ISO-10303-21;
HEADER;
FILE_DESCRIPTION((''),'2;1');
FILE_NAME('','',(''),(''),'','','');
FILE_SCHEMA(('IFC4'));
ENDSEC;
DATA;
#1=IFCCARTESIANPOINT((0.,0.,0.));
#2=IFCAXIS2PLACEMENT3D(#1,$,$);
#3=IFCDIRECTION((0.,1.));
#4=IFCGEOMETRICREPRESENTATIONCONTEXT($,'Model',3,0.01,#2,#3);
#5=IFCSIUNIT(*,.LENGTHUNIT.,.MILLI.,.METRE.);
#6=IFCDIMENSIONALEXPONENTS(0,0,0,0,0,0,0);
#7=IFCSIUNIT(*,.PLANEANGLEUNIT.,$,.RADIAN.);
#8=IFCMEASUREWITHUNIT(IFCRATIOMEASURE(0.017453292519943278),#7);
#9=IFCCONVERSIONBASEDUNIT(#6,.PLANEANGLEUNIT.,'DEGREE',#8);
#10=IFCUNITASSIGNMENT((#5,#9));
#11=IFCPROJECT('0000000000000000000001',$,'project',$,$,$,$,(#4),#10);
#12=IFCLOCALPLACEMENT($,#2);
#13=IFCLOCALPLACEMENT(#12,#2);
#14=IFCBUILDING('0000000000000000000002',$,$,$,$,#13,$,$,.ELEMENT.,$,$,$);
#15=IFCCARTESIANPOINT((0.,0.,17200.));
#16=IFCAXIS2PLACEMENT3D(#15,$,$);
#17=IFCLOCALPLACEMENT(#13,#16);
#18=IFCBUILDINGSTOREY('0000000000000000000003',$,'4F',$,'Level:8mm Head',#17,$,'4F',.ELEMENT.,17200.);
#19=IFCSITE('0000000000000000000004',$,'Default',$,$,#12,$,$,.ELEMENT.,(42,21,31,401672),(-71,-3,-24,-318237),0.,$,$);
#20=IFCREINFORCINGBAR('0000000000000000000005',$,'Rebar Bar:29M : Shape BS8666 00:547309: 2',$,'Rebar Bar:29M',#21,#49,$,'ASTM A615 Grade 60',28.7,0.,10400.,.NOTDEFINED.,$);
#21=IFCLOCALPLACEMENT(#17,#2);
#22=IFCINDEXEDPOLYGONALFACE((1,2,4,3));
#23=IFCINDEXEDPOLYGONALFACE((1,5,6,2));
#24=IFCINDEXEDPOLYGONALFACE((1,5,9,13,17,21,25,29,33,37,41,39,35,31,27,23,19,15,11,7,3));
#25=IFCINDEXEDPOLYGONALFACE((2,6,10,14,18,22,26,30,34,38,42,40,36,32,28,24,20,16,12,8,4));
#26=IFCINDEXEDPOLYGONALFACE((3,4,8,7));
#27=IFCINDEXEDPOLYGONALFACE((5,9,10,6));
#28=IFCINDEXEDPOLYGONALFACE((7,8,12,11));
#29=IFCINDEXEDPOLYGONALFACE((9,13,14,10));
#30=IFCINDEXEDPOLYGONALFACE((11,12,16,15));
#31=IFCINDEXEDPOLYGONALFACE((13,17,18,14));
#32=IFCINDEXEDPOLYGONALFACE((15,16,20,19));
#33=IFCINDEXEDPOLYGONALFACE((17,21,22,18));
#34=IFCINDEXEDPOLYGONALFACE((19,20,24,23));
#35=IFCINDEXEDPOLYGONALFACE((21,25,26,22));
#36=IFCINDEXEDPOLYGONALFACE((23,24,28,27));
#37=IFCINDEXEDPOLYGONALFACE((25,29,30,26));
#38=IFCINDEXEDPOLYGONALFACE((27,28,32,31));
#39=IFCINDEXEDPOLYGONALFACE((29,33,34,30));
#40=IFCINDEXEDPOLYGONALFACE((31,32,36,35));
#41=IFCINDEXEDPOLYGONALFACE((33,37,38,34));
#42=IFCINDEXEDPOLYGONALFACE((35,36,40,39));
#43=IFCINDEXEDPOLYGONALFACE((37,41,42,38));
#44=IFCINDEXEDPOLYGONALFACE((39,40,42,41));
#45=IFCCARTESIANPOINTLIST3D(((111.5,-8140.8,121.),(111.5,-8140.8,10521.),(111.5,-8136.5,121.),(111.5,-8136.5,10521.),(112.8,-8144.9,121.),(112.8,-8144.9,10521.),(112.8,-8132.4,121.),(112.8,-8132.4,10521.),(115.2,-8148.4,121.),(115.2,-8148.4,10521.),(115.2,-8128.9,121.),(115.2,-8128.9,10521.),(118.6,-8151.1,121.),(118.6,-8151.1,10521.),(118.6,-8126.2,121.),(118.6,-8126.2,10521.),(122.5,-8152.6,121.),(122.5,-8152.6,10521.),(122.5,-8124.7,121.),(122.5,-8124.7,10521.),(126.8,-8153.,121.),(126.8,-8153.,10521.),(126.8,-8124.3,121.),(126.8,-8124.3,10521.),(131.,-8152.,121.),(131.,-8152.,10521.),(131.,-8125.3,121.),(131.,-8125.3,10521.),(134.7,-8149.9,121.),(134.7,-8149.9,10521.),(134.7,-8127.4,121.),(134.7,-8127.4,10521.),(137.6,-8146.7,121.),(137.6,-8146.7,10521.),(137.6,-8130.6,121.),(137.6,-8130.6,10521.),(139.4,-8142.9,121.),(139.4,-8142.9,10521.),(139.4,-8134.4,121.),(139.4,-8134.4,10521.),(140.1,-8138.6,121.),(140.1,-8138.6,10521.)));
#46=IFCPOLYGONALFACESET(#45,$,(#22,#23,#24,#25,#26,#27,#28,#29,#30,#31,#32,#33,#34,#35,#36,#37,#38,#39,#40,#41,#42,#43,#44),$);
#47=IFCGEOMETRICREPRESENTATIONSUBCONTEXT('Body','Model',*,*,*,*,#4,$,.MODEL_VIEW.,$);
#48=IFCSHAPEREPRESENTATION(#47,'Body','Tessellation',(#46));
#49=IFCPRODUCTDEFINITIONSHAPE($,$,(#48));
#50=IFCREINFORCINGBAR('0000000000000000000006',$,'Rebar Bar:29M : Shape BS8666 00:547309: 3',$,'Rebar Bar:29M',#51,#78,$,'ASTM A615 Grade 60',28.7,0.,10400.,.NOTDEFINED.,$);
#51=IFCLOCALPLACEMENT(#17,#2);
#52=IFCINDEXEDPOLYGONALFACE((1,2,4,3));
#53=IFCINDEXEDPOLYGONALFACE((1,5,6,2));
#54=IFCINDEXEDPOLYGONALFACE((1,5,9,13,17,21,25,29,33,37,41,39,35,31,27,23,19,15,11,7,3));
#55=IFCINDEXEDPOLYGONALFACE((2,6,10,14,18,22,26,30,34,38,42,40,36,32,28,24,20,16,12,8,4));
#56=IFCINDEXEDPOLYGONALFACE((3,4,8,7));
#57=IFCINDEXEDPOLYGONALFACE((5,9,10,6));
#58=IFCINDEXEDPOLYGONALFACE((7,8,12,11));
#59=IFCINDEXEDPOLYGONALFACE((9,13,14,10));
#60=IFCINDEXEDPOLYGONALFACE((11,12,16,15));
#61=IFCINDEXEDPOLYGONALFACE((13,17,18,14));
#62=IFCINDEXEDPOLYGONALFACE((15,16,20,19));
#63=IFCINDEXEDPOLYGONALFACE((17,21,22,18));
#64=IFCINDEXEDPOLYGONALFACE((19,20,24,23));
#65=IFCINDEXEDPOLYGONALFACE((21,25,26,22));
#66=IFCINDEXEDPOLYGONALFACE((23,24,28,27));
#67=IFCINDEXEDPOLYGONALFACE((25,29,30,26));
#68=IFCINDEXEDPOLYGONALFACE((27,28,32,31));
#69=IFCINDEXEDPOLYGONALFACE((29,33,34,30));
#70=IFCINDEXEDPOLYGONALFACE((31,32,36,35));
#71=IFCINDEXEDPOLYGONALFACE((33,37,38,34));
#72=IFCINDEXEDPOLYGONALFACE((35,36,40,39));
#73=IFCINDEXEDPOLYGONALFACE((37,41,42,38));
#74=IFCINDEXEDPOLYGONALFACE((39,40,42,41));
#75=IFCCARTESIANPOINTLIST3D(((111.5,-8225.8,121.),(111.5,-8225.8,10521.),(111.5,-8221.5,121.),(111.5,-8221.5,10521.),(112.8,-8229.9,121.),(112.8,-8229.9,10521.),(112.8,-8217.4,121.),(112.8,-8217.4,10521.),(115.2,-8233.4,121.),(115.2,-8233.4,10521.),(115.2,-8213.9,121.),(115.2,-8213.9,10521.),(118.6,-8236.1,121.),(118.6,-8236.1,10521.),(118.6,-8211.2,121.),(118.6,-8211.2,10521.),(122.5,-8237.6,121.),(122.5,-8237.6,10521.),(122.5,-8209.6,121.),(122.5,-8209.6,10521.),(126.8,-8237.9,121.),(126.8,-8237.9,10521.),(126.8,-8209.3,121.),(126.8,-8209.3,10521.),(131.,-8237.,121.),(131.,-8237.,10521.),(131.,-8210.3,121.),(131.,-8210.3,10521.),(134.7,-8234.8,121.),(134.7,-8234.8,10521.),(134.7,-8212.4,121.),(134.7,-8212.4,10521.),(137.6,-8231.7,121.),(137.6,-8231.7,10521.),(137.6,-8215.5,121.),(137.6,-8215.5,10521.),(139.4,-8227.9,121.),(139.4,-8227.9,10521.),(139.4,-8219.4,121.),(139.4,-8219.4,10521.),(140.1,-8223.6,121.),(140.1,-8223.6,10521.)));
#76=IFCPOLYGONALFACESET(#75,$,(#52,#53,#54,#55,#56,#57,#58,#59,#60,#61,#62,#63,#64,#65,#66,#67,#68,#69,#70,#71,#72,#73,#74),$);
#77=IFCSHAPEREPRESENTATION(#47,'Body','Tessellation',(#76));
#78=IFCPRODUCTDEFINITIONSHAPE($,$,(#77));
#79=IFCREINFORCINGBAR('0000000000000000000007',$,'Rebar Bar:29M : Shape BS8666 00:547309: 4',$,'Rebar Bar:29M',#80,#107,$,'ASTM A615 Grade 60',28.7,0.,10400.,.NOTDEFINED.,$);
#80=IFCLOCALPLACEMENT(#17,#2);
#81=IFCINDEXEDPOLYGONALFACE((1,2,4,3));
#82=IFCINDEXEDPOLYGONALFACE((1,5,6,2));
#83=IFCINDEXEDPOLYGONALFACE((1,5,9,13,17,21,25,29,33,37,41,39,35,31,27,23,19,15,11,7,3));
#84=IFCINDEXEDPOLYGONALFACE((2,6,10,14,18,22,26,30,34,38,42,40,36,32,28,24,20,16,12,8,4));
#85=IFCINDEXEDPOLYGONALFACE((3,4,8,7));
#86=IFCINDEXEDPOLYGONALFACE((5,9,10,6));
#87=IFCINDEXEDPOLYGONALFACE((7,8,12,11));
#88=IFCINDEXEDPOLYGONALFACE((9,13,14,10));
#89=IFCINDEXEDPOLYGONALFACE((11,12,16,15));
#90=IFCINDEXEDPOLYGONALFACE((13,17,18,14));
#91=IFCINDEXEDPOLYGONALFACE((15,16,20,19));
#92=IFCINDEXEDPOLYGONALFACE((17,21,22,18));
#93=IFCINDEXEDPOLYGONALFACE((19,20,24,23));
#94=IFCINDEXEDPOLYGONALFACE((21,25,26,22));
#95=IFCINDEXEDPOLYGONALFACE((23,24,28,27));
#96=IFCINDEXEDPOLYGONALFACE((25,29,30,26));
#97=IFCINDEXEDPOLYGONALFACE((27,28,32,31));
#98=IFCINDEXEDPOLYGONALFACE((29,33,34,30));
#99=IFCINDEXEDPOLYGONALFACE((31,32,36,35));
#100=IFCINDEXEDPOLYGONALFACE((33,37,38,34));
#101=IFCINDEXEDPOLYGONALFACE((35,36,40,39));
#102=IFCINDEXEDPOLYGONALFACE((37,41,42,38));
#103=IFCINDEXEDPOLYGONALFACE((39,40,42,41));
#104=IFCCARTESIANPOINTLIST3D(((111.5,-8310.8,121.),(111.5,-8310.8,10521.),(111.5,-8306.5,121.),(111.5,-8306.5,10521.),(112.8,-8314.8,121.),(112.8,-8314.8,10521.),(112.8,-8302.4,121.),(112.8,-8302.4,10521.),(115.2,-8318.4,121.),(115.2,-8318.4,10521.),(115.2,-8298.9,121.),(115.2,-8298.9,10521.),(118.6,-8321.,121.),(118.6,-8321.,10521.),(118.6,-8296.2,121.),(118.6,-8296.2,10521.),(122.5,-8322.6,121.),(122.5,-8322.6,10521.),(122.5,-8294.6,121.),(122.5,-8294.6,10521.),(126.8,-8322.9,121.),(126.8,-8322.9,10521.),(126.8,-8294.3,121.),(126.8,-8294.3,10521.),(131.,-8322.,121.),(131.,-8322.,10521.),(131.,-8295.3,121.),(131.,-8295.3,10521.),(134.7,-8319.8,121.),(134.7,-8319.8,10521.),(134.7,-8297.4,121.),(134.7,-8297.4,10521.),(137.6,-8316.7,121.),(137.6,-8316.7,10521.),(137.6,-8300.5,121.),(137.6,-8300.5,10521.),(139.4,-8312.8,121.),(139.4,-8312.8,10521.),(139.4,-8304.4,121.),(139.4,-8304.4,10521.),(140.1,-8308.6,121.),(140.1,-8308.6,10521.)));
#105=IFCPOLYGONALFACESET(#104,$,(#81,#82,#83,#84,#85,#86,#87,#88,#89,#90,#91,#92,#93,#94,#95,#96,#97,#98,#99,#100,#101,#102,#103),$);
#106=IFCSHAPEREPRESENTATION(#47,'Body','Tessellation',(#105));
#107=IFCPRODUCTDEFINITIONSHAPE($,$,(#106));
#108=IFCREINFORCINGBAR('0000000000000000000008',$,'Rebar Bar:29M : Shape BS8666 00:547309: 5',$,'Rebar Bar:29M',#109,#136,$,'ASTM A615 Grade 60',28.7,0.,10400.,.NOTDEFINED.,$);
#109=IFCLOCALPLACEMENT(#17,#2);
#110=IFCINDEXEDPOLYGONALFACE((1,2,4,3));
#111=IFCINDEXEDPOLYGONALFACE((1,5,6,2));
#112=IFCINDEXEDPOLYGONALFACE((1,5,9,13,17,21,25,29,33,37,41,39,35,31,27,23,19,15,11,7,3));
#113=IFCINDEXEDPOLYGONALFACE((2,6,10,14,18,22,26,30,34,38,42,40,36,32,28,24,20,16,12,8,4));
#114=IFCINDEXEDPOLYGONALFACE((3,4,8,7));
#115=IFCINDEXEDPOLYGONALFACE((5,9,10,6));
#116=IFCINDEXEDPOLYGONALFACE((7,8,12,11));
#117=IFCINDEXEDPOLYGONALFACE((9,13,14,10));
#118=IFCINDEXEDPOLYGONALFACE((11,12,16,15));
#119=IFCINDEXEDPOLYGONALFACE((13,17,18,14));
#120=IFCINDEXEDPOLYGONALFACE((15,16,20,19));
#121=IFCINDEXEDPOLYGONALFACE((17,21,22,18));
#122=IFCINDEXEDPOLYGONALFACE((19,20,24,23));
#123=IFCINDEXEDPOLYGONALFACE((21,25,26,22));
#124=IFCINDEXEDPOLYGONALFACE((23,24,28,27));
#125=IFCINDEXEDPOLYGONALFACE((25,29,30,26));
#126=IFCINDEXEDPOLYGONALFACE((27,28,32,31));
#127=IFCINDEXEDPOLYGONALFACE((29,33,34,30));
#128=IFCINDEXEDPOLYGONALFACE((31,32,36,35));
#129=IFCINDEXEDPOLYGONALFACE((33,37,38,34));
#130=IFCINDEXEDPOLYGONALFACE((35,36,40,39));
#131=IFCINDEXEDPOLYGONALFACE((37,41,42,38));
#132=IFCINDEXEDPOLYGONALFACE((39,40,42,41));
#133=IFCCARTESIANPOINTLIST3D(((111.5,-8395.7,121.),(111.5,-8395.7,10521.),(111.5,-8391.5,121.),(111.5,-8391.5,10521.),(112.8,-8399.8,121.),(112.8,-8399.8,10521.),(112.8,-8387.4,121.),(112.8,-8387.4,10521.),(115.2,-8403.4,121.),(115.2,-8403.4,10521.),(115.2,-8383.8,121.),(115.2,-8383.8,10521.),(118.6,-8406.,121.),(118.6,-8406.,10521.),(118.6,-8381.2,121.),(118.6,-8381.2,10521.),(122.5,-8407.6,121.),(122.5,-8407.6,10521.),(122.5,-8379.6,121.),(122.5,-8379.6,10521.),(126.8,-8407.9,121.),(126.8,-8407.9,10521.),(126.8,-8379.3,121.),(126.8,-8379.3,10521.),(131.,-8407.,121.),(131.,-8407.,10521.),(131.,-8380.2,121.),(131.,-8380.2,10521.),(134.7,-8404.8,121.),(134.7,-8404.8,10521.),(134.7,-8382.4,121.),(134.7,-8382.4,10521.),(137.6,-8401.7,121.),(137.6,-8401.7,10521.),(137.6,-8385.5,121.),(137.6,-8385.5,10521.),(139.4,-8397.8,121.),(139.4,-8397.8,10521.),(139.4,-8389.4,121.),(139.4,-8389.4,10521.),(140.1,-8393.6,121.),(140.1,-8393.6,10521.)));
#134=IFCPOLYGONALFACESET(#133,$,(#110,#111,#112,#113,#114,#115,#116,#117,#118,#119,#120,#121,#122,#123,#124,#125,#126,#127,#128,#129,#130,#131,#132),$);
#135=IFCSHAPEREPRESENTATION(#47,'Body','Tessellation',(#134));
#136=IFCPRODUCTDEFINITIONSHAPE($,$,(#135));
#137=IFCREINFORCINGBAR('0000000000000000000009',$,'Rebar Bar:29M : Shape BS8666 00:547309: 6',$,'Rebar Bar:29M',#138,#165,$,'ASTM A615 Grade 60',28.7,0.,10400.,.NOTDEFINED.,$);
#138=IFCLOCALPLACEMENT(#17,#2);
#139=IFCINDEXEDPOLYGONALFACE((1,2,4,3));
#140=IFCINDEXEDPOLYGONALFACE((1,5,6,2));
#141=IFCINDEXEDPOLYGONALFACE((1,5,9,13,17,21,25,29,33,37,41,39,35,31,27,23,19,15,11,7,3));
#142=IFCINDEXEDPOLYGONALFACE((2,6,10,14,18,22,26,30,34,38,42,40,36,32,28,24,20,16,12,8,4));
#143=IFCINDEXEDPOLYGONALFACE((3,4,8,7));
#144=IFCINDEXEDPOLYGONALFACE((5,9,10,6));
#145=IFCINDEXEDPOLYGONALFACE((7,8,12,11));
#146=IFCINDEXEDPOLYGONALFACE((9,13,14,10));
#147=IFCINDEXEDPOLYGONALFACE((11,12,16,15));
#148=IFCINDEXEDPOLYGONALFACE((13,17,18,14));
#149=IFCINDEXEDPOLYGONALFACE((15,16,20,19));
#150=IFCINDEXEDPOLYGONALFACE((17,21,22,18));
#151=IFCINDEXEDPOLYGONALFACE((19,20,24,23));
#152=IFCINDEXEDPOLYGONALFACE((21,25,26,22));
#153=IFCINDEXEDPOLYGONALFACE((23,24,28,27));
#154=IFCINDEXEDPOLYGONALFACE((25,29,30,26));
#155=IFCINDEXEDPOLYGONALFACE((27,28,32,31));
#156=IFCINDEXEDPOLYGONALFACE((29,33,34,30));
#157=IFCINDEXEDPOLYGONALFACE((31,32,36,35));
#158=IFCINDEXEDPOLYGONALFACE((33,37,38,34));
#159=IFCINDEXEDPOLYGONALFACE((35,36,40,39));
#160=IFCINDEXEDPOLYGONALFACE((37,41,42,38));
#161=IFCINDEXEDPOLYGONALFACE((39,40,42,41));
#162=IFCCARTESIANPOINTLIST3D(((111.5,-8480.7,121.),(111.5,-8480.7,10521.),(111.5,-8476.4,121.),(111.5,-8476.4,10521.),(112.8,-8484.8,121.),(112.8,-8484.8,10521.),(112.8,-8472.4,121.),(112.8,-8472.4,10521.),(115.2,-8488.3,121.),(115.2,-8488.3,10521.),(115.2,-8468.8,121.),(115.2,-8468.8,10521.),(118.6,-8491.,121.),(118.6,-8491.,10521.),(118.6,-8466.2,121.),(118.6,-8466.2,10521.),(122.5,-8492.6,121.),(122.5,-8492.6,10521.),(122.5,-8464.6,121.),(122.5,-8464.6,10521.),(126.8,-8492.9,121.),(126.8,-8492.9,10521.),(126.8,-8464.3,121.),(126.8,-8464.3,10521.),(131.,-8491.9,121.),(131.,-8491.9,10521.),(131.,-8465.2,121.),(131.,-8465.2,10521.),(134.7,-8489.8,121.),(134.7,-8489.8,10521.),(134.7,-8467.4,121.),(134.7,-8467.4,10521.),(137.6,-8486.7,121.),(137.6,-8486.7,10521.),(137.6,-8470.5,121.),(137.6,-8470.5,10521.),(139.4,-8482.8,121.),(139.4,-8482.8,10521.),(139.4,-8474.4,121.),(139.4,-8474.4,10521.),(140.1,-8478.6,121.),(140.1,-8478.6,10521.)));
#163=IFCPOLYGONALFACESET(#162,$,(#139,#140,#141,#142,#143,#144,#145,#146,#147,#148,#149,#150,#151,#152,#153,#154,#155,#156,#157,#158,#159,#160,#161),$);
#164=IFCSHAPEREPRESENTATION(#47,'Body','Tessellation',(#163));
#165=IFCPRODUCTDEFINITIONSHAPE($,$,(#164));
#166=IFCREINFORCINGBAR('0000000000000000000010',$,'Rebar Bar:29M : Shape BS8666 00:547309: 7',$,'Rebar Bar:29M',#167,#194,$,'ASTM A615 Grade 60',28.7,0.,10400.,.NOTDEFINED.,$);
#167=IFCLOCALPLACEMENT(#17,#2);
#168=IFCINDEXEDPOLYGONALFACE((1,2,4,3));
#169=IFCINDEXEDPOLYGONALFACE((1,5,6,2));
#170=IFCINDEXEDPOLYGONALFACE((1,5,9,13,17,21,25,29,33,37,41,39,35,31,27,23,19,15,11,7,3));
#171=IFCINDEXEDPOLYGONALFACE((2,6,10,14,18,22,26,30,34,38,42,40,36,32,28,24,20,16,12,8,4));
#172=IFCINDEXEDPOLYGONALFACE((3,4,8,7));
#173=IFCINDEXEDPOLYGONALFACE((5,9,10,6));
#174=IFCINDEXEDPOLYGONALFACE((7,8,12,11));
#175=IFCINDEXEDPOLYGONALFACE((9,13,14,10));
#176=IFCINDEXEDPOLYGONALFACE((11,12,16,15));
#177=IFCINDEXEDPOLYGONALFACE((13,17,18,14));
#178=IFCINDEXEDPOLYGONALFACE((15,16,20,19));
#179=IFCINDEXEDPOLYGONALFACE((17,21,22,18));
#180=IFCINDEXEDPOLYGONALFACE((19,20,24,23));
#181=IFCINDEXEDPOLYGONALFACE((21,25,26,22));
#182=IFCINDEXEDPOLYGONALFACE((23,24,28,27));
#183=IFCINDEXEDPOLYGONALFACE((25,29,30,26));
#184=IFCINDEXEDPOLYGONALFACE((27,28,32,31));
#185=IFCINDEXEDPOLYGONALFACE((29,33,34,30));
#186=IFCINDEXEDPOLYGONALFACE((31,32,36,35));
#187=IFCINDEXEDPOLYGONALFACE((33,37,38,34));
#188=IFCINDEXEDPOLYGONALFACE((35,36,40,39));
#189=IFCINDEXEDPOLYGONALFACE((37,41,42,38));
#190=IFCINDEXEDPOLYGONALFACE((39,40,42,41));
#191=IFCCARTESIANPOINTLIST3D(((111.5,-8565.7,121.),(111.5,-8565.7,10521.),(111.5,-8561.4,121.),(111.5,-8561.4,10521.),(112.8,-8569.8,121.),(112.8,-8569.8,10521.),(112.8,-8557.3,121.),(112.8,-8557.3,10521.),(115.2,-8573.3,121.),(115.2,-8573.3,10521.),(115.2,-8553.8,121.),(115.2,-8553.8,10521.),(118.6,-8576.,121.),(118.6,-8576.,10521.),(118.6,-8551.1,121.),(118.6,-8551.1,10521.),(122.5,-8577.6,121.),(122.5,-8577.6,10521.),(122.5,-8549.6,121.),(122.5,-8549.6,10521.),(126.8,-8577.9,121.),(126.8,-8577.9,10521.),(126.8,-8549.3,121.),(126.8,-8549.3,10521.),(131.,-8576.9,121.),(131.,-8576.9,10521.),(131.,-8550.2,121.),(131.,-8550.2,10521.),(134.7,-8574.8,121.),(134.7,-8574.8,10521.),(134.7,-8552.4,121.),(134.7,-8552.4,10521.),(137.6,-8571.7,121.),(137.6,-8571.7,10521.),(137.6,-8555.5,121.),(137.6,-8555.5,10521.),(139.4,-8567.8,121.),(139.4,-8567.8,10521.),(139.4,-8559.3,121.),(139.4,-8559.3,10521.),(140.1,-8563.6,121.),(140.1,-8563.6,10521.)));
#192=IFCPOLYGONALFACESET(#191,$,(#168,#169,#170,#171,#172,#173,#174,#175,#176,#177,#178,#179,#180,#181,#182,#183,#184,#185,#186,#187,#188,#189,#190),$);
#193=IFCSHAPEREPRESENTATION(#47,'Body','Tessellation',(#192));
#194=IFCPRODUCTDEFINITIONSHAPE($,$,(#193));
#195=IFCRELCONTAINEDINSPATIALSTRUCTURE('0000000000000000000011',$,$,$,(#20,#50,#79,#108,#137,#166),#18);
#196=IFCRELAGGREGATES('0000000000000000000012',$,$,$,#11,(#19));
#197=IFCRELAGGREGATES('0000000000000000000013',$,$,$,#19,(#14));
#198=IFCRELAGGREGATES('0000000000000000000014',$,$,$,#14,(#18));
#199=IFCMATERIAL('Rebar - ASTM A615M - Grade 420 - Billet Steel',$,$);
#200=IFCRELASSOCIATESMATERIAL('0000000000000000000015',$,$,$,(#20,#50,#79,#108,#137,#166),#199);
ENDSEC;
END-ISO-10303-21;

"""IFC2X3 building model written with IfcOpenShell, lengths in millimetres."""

from ifc_helpers import new_model, entity, si_unit, converted_unit, direction, frame, origin, place, context, subcontext, project, spatial, material, element, save


model = new_model("IFC2X3")

# Units and contexts
model_context = context("Model", 3, precision=0.01, world=origin(), true_north=direction((0.0, 1.0)))
body_context = subcontext(model_context, "Body", "Model", "MODEL_VIEW")
ifc_project = project(units=[si_unit("LENGTHUNIT", "METRE", prefix="MILLI"), converted_unit("PLANEANGLEUNIT", "DEGREE", entity("IfcRatioMeasure", 0.017453292519943278), si_unit("PLANEANGLEUNIT", "RADIAN"), dimensions=[0, 0, 0, 0, 0, 0, 0])], contexts=[model_context])

# Site, building, storey
site_placement = place(None, origin())
site = spatial("IfcSite", under=ifc_project, at=site_placement, Name="Default", CompositionType="ELEMENT", RefLatitude=(42, 21, 31, 401672), RefLongitude=(-71, -3, -24, -318237), RefElevation=0.0)
building_placement = place(site_placement, origin())
building = spatial("IfcBuilding", under=site, at=building_placement, CompositionType="ELEMENT")
storey_placement = place(building_placement, frame((0.0, 0.0, 17200.0)))
storey = spatial("IfcBuildingStorey", under=building, at=storey_placement, Name="4F", ObjectType="Level:8mm Head", LongName="4F", CompositionType="ELEMENT", Elevation=17200.0)

# Reinforcing bars
ifc_material_1 = material(Name="Rebar - ASTM A615M - Grade 420 - Billet Steel")
reinforcing_bar_1_placement = place(storey_placement, origin())
element("IfcReinforcingBar", 1, at=reinforcing_bar_1_placement, inside=storey, material=ifc_material_1, Name="Rebar Bar:29M : Shape BS8666 00:547309: 2", SteelGrade="ASTM A615 Grade 60", ObjectType="Rebar Bar:29M", BarLength=10400.0, BarRole="NOTDEFINED", CrossSectionArea=0.0, NominalDiameter=28.7, context=body_context, shape_type="AdvancedSweptSolid", body=[
    entity("IfcSweptDiskSolid", entity("IfcCompositeCurve", [entity("IfcCompositeCurveSegment", "CONTINUOUS", True, entity("IfcPolyline", [entity("IfcCartesianPoint", [125.7, -8138.6, 121.0]), entity("IfcCartesianPoint", [125.7, -8138.6, 10521.0])]))], False), 14.3, None, 0.0, 1.0),
])
reinforcing_bar_2_placement = place(storey_placement, origin())
element("IfcReinforcingBar", 2, at=reinforcing_bar_2_placement, inside=storey, material=ifc_material_1, Name="Rebar Bar:29M : Shape BS8666 00:547309: 3", SteelGrade="ASTM A615 Grade 60", ObjectType="Rebar Bar:29M", BarLength=10400.0, BarRole="NOTDEFINED", CrossSectionArea=0.0, NominalDiameter=28.7, context=body_context, shape_type="AdvancedSweptSolid", body=[
    entity("IfcSweptDiskSolid", entity("IfcCompositeCurve", [entity("IfcCompositeCurveSegment", "CONTINUOUS", True, entity("IfcPolyline", [entity("IfcCartesianPoint", [125.7, -8223.6, 121.0]), entity("IfcCartesianPoint", [125.7, -8223.6, 10521.0])]))], False), 14.3, None, 0.0, 1.0),
])
reinforcing_bar_3_placement = place(storey_placement, origin())
element("IfcReinforcingBar", 3, at=reinforcing_bar_3_placement, inside=storey, material=ifc_material_1, Name="Rebar Bar:29M : Shape BS8666 00:547309: 4", SteelGrade="ASTM A615 Grade 60", ObjectType="Rebar Bar:29M", BarLength=10400.0, BarRole="NOTDEFINED", CrossSectionArea=0.0, NominalDiameter=28.7, context=body_context, shape_type="AdvancedSweptSolid", body=[
    entity("IfcSweptDiskSolid", entity("IfcCompositeCurve", [entity("IfcCompositeCurveSegment", "CONTINUOUS", True, entity("IfcPolyline", [entity("IfcCartesianPoint", [125.7, -8308.6, 121.0]), entity("IfcCartesianPoint", [125.7, -8308.6, 10521.0])]))], False), 14.3, None, 0.0, 1.0),
])
reinforcing_bar_4_placement = place(storey_placement, origin())
element("IfcReinforcingBar", 4, at=reinforcing_bar_4_placement, inside=storey, material=ifc_material_1, Name="Rebar Bar:29M : Shape BS8666 00:547309: 5", SteelGrade="ASTM A615 Grade 60", ObjectType="Rebar Bar:29M", BarLength=10400.0, BarRole="NOTDEFINED", CrossSectionArea=0.0, NominalDiameter=28.7, context=body_context, shape_type="AdvancedSweptSolid", body=[
    entity("IfcSweptDiskSolid", entity("IfcCompositeCurve", [entity("IfcCompositeCurveSegment", "CONTINUOUS", True, entity("IfcPolyline", [entity("IfcCartesianPoint", [125.7, -8393.6, 121.0]), entity("IfcCartesianPoint", [125.7, -8393.6, 10521.0])]))], False), 14.3, None, 0.0, 1.0),
])
reinforcing_bar_5_placement = place(storey_placement, origin())
element("IfcReinforcingBar", 5, at=reinforcing_bar_5_placement, inside=storey, material=ifc_material_1, Name="Rebar Bar:29M : Shape BS8666 00:547309: 6", SteelGrade="ASTM A615 Grade 60", ObjectType="Rebar Bar:29M", BarLength=10400.0, BarRole="NOTDEFINED", CrossSectionArea=0.0, NominalDiameter=28.7, context=body_context, shape_type="AdvancedSweptSolid", body=[
    entity("IfcSweptDiskSolid", entity("IfcCompositeCurve", [entity("IfcCompositeCurveSegment", "CONTINUOUS", True, entity("IfcPolyline", [entity("IfcCartesianPoint", [125.7, -8478.6, 121.0]), entity("IfcCartesianPoint", [125.7, -8478.6, 10521.0])]))], False), 14.3, None, 0.0, 1.0),
])
reinforcing_bar_6_placement = place(storey_placement, origin())
element("IfcReinforcingBar", 6, at=reinforcing_bar_6_placement, inside=storey, material=ifc_material_1, Name="Rebar Bar:29M : Shape BS8666 00:547309: 7", SteelGrade="ASTM A615 Grade 60", ObjectType="Rebar Bar:29M", BarLength=10400.0, BarRole="NOTDEFINED", CrossSectionArea=0.0, NominalDiameter=28.7, context=body_context, shape_type="AdvancedSweptSolid", body=[
    entity("IfcSweptDiskSolid", entity("IfcCompositeCurve", [entity("IfcCompositeCurveSegment", "CONTINUOUS", True, entity("IfcPolyline", [entity("IfcCartesianPoint", [125.7, -8563.6, 121.0]), entity("IfcCartesianPoint", [125.7, -8563.6, 10521.0])]))], False), 14.3, None, 0.0, 1.0),
])

save(model, "model.ifc")
